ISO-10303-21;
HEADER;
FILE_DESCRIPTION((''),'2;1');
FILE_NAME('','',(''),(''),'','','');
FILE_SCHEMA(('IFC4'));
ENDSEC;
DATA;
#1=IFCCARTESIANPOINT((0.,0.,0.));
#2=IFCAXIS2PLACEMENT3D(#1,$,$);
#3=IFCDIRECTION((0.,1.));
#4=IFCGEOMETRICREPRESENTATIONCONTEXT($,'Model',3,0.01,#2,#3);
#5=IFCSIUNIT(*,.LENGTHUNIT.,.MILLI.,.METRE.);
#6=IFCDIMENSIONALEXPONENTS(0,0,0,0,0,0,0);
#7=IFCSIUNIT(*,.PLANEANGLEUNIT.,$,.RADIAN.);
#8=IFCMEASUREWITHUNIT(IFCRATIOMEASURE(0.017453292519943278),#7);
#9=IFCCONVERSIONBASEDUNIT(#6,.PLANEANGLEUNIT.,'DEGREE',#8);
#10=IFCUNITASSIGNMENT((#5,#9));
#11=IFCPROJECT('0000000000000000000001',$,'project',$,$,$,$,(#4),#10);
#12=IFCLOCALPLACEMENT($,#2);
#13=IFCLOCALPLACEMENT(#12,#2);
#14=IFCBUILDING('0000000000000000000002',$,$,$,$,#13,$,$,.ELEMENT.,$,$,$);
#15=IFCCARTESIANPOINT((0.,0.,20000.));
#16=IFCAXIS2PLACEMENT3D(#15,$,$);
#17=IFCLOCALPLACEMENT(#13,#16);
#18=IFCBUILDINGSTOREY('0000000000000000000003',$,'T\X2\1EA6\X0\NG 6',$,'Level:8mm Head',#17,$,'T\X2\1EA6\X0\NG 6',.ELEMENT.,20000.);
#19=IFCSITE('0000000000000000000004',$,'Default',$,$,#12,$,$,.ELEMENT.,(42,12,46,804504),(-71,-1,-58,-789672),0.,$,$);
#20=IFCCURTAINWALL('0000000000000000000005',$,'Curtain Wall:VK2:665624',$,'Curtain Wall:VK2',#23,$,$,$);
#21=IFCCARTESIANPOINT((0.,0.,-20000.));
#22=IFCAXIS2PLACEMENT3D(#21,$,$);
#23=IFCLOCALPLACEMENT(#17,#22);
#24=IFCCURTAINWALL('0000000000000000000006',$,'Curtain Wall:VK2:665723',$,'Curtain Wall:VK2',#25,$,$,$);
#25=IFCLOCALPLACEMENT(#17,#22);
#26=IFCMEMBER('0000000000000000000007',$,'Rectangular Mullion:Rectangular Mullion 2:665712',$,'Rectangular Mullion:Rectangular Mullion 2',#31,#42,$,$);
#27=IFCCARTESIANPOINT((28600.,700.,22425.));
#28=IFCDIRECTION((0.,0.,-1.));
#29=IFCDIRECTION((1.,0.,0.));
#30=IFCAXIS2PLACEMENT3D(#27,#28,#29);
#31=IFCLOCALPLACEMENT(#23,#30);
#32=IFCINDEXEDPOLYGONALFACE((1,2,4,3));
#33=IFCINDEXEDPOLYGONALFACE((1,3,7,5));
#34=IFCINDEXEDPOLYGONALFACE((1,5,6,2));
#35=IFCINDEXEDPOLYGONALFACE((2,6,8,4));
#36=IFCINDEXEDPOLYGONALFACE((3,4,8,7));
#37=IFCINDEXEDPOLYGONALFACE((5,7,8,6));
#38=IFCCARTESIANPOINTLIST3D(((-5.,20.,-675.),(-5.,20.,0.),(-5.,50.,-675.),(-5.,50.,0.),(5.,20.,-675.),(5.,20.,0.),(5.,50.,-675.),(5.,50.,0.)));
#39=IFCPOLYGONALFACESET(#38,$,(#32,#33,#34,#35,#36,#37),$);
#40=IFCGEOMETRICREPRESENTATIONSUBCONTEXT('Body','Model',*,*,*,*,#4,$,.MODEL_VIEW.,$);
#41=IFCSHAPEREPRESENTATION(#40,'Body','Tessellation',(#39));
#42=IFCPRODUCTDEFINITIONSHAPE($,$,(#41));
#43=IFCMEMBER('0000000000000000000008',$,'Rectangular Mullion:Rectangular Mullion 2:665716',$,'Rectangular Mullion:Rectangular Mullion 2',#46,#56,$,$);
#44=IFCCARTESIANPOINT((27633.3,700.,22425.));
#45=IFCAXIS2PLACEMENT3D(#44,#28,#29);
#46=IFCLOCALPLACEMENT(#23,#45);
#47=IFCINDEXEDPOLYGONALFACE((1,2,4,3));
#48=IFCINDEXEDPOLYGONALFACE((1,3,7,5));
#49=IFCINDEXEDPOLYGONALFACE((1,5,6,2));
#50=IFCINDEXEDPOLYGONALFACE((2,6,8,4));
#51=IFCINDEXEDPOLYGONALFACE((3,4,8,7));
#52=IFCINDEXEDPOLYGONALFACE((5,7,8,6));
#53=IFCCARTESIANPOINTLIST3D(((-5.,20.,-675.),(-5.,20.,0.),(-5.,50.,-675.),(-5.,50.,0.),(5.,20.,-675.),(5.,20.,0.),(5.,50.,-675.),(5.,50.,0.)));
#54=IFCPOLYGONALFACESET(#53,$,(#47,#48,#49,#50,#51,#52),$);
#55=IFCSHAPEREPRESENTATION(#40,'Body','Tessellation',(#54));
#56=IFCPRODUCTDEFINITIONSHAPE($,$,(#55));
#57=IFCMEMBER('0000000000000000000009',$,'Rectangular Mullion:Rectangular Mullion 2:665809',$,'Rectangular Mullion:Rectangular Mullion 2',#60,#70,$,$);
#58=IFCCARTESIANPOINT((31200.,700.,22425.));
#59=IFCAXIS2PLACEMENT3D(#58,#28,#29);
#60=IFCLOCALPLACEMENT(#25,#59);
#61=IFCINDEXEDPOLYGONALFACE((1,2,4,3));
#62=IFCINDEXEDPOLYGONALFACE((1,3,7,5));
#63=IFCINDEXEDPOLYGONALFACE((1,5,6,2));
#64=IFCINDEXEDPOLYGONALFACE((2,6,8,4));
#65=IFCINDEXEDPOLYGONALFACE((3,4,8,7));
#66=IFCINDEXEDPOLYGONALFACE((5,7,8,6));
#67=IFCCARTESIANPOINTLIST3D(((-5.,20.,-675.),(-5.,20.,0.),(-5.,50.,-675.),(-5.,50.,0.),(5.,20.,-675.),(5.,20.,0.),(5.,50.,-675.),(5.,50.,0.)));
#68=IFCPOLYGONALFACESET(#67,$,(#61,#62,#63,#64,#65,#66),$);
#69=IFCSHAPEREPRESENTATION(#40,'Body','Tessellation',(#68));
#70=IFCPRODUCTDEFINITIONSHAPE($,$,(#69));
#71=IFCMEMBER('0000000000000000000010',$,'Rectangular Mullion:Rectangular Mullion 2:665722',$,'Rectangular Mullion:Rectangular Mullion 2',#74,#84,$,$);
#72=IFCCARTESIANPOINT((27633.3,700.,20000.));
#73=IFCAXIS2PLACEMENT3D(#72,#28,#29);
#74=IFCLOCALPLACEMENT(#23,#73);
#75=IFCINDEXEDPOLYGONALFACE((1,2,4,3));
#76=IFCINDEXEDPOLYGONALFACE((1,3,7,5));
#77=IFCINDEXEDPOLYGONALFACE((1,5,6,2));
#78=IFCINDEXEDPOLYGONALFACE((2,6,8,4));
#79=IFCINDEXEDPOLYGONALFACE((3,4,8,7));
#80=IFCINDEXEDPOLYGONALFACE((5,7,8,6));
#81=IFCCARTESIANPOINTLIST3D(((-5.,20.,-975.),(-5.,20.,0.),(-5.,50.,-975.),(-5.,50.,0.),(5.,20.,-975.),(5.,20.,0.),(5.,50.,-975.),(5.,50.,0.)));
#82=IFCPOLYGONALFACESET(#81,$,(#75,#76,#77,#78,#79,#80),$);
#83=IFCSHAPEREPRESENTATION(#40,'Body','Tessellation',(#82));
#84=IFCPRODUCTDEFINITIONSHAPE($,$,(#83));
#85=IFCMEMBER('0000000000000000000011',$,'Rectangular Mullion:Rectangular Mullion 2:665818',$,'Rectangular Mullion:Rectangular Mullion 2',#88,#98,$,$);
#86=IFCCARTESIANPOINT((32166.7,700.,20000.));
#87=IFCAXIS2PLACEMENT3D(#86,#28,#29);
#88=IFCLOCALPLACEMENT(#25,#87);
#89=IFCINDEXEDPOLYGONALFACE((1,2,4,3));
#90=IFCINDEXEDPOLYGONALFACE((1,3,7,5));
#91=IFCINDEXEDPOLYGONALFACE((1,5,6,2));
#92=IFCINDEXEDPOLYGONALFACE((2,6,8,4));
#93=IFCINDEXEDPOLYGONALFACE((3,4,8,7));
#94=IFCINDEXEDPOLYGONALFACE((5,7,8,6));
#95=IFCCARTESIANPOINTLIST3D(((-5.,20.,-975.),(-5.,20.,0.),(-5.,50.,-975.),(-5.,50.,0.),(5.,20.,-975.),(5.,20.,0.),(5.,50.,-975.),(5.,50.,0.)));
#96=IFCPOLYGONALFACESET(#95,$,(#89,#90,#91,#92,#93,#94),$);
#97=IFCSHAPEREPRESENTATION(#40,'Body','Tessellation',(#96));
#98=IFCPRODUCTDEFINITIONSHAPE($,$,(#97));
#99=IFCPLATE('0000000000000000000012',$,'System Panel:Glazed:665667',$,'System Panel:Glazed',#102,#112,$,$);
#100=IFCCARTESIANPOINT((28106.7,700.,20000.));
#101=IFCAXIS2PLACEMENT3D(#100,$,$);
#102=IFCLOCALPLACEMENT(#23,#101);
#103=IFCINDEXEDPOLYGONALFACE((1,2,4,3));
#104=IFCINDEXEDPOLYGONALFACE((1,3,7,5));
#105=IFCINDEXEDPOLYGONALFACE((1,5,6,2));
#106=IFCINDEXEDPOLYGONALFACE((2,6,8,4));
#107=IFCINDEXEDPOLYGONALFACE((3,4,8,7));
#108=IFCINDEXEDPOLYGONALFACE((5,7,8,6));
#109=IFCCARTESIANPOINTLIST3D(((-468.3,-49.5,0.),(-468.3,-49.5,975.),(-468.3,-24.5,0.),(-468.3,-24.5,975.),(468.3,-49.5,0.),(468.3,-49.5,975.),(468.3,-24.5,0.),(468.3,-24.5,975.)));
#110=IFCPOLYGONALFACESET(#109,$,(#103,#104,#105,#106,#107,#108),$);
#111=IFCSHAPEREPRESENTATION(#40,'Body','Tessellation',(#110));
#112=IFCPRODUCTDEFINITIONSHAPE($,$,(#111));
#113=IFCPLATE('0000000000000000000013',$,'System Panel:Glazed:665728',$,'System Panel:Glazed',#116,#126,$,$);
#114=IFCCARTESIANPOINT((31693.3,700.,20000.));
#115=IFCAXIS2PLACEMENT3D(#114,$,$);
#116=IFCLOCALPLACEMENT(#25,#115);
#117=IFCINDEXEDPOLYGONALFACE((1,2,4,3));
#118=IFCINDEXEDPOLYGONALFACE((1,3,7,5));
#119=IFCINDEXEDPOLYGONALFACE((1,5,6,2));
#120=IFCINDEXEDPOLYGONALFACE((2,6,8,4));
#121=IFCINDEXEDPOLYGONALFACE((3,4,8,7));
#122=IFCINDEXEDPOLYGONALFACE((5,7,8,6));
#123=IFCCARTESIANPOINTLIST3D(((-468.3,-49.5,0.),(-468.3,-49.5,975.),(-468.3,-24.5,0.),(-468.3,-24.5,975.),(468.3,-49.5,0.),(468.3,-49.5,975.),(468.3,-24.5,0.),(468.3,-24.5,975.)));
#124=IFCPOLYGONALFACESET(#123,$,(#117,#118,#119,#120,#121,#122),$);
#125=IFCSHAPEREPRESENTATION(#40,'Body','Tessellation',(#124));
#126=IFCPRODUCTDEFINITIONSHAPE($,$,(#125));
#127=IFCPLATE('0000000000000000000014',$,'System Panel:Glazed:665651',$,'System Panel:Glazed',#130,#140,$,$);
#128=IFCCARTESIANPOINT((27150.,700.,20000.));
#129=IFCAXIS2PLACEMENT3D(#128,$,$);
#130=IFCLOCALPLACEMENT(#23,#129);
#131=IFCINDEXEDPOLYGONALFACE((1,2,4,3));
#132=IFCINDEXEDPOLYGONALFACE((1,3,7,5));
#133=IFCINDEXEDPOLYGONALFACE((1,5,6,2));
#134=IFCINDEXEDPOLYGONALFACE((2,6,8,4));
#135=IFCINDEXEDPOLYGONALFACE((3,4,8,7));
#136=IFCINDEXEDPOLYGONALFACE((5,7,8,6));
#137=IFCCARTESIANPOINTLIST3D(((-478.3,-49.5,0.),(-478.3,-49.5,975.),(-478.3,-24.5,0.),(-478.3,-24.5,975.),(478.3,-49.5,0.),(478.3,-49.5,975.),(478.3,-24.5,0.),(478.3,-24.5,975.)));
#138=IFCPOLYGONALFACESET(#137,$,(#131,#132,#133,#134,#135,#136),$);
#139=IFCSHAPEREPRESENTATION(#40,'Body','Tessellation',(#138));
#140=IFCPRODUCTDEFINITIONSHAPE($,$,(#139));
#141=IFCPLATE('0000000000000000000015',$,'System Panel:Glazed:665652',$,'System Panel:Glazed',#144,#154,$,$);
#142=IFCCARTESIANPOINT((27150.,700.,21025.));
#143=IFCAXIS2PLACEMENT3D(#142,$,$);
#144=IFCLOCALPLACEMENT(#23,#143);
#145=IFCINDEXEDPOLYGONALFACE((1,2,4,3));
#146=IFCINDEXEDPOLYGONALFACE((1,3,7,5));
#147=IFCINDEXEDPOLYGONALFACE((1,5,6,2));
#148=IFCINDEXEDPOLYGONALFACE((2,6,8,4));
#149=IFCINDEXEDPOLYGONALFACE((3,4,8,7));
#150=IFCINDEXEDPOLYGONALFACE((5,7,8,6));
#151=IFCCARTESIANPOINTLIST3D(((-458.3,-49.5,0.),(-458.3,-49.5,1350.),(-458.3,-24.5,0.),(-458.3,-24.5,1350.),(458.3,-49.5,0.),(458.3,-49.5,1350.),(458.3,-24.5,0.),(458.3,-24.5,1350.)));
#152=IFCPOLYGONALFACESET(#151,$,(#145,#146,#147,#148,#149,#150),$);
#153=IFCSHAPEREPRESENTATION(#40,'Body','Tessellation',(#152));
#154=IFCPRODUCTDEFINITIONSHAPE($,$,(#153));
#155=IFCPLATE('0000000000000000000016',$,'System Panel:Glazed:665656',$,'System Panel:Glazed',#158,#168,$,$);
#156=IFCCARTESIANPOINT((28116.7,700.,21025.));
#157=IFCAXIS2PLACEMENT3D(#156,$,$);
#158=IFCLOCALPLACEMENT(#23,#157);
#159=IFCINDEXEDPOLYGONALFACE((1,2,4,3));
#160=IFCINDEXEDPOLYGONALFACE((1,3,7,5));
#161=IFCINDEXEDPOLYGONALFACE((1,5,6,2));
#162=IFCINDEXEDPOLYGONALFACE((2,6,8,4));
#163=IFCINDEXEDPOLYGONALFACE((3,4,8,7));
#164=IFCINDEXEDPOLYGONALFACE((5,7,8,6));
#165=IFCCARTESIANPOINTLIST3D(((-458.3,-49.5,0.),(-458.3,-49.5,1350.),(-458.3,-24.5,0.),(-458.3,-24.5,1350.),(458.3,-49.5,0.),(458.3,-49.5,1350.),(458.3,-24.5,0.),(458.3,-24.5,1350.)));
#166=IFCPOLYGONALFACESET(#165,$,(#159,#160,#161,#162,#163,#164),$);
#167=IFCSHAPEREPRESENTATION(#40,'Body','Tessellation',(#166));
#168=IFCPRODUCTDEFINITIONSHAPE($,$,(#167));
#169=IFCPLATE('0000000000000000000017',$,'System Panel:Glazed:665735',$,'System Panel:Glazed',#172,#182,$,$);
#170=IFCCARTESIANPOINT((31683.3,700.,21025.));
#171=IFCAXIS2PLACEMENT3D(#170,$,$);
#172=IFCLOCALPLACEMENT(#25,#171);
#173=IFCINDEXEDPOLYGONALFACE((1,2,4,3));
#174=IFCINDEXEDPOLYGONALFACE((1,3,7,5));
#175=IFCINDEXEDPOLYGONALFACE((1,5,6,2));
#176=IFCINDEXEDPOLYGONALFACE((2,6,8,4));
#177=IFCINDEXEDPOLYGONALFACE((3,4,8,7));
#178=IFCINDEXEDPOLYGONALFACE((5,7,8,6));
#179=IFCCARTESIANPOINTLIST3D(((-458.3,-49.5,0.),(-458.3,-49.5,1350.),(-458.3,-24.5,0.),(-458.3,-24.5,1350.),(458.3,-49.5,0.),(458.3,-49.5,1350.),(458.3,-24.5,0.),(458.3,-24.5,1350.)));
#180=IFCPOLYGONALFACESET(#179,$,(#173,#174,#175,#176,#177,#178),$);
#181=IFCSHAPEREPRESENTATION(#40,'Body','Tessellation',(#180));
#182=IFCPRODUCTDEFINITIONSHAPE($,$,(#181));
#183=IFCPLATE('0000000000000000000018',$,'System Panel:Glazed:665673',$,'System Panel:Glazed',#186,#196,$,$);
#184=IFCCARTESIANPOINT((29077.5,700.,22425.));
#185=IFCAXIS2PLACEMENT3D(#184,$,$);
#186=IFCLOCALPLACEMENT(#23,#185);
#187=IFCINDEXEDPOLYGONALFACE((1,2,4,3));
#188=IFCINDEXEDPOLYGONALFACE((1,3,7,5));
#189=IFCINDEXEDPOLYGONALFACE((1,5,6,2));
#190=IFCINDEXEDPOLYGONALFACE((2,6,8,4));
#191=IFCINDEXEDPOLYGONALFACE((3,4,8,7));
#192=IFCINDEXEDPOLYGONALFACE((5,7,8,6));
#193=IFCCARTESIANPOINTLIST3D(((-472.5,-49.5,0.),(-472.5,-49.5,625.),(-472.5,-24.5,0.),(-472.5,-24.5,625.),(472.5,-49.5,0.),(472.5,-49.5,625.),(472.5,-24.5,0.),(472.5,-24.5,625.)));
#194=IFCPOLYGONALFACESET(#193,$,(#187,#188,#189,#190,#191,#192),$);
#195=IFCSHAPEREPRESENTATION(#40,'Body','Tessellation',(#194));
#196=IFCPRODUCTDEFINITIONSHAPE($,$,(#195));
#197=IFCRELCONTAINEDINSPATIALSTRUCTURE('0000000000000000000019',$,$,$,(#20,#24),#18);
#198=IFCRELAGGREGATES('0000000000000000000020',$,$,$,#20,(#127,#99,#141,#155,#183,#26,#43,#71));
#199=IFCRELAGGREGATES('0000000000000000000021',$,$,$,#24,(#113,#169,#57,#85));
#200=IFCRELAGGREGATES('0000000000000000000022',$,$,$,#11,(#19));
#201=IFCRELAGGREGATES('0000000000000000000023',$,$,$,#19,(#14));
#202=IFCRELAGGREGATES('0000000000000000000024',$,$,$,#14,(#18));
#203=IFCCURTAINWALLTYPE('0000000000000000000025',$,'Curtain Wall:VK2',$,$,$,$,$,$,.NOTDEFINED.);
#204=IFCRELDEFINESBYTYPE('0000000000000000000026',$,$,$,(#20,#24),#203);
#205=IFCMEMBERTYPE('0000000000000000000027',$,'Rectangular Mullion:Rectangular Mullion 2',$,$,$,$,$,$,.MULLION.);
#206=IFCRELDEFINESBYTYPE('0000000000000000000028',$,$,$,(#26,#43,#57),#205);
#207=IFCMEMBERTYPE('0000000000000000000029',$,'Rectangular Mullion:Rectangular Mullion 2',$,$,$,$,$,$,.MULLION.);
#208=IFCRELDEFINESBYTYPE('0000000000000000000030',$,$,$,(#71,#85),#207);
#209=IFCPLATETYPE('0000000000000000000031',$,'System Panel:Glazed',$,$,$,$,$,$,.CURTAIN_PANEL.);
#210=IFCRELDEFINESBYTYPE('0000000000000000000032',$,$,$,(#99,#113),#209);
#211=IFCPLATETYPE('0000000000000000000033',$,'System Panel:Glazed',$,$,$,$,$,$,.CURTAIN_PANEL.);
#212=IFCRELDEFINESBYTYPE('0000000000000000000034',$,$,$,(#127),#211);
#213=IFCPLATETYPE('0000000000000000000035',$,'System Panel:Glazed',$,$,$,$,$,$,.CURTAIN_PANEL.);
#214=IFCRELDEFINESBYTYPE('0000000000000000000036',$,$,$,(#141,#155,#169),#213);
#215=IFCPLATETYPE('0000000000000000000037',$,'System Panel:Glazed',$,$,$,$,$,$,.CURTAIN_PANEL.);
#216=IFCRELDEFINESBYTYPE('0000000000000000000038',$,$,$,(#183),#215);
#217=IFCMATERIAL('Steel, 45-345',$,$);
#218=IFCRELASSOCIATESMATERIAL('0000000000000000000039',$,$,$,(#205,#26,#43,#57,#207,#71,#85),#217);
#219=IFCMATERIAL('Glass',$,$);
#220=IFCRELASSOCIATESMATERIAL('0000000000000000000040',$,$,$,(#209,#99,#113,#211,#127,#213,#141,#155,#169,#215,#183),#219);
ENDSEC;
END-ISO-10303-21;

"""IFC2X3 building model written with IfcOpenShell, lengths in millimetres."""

from ifc_helpers import new_model, entity, si_unit, converted_unit, direction, frame, frame_2d, origin, origin_2d_with_axis, place, context, subcontext, project, spatial, rectangle, extrude, source, transform, mapped, material, type_object, type_shapes, element, aggregate, save


model = new_model("IFC2X3")

# Units and contexts
model_context = context("Model", 3, precision=0.01, world=origin(), true_north=direction((0.0, 1.0)))
body_context = subcontext(model_context, "Body", "Model", "MODEL_VIEW")
ifc_project = project(units=[si_unit("LENGTHUNIT", "METRE", prefix="MILLI"), converted_unit("PLANEANGLEUNIT", "DEGREE", entity("IfcRatioMeasure", 0.017453292519943278), si_unit("PLANEANGLEUNIT", "RADIAN"), dimensions=[0, 0, 0, 0, 0, 0, 0])], contexts=[model_context])

# Site, building, storey
site_placement = place(None, origin())
site = spatial("IfcSite", under=ifc_project, at=site_placement, Name="Default", CompositionType="ELEMENT", RefLatitude=(42, 12, 46, 804504), RefLongitude=(-71, -1, -58, -789672), RefElevation=0.0)
building_placement = place(site_placement, origin())
building = spatial("IfcBuilding", under=site, at=building_placement, CompositionType="ELEMENT")
storey_placement = place(building_placement, frame((0.0, 0.0, 20000.0)))
storey = spatial("IfcBuildingStorey", under=building, at=storey_placement, Name="TẦNG 6", ObjectType="Level:8mm Head", LongName="TẦNG 6", CompositionType="ELEMENT", Elevation=20000.0)

# Curtain wall
curtain_wall_type = type_object("IfcCurtainWallType", Name="Curtain Wall:VK2", PredefinedType="NOTDEFINED")
curtain_wall_1_placement = place(storey_placement, frame((0.0, 0.0, -20000.0)))
curtain_wall_1 = element("IfcCurtainWall", 1, at=curtain_wall_1_placement, inside=storey, type_object=curtain_wall_type, Name="Curtain Wall:VK2:665624", ObjectType="Curtain Wall:VK2")
ifc_material_1 = material(Name="Steel, 45-345")

# Curtain wall
curtain_wall_2_placement = place(storey_placement, frame((0.0, 0.0, -20000.0)))
curtain_wall_2 = element("IfcCurtainWall", 2, at=curtain_wall_2_placement, inside=storey, type_object=curtain_wall_type, Name="Curtain Wall:VK2:665723", ObjectType="Curtain Wall:VK2")

# Members
member_type_1 = type_object("IfcMemberType", Name="Rectangular Mullion:Rectangular Mullion 2", PredefinedType="MULLION", material=ifc_material_1)
shared_shape_1 = source(origin(), body_context, "Body", "SweptSolid", [
    extrude(rectangle(XDim=30.0, YDim=10.0, at=origin_2d_with_axis()), frame((0.0, 35.0, -675.0), z_axis=(0.0, 0.0, 1.0), x_axis=(0.0, -1.0, 0.0)), (0.0, 0.0, 1.0), 675.0),
])
type_shapes(member_type_1, [shared_shape_1])
member_1_placement = place(curtain_wall_1_placement, frame((28600.0, 700.0, 22425.0), z_axis=(0.0, 0.0, -1.0), x_axis=(1.0, 0.0, 0.0)))
member_1 = element("IfcMember", 3, at=member_1_placement, type_object=member_type_1, material=ifc_material_1, Name="Rectangular Mullion:Rectangular Mullion 2:665712", ObjectType="Rectangular Mullion:Rectangular Mullion 2", context=body_context, shape_type="MappedRepresentation", body=[
    mapped(shared_shape_1, transform((0.0, 0.0, 0.0), scale=1.0)),
])
member_2_placement = place(curtain_wall_1_placement, frame((27633.3, 700.0, 22425.0), z_axis=(0.0, 0.0, -1.0), x_axis=(1.0, 0.0, 0.0)))
member_2 = element("IfcMember", 4, at=member_2_placement, type_object=member_type_1, material=ifc_material_1, Name="Rectangular Mullion:Rectangular Mullion 2:665716", ObjectType="Rectangular Mullion:Rectangular Mullion 2", context=body_context, shape_type="MappedRepresentation", body=[
    mapped(shared_shape_1, transform((0.0, 0.0, 0.0), scale=1.0)),
])
member_3_placement = place(curtain_wall_2_placement, frame((31200.0, 700.0, 22425.0), z_axis=(0.0, 0.0, -1.0), x_axis=(1.0, 0.0, 0.0)))
member_3 = element("IfcMember", 5, at=member_3_placement, type_object=member_type_1, material=ifc_material_1, Name="Rectangular Mullion:Rectangular Mullion 2:665809", ObjectType="Rectangular Mullion:Rectangular Mullion 2", context=body_context, shape_type="MappedRepresentation", body=[
    mapped(shared_shape_1, transform((0.0, 0.0, 0.0), scale=1.0)),
])
member_type_2 = type_object("IfcMemberType", Name="Rectangular Mullion:Rectangular Mullion 2", PredefinedType="MULLION", material=ifc_material_1)
shared_shape_2 = source(origin(), body_context, "Body", "SweptSolid", [
    extrude(rectangle(XDim=30.0, YDim=10.0, at=origin_2d_with_axis()), frame((0.0, 35.0, -975.0), z_axis=(0.0, 0.0, 1.0), x_axis=(0.0, -1.0, 0.0)), (0.0, 0.0, 1.0), 975.0),
])
type_shapes(member_type_2, [shared_shape_2])
member_4_placement = place(curtain_wall_1_placement, frame((27633.3, 700.0, 20000.0), z_axis=(0.0, 0.0, -1.0), x_axis=(1.0, 0.0, 0.0)))
member_4 = element("IfcMember", 6, at=member_4_placement, type_object=member_type_2, material=ifc_material_1, Name="Rectangular Mullion:Rectangular Mullion 2:665722", ObjectType="Rectangular Mullion:Rectangular Mullion 2", context=body_context, shape_type="MappedRepresentation", body=[
    mapped(shared_shape_2, transform((0.0, 0.0, 0.0), scale=1.0)),
])
member_5_placement = place(curtain_wall_2_placement, frame((32166.7, 700.0, 20000.0), z_axis=(0.0, 0.0, -1.0), x_axis=(1.0, 0.0, 0.0)))
member_5 = element("IfcMember", 7, at=member_5_placement, type_object=member_type_2, material=ifc_material_1, Name="Rectangular Mullion:Rectangular Mullion 2:665818", ObjectType="Rectangular Mullion:Rectangular Mullion 2", context=body_context, shape_type="MappedRepresentation", body=[
    mapped(shared_shape_2, transform((0.0, 0.0, 0.0), scale=1.0)),
])

# Plates
ifc_material_2 = material(Name="Glass")
plate_type_1 = type_object("IfcPlateType", Name="System Panel:Glazed", PredefinedType="CURTAIN_PANEL", material=ifc_material_2)
shared_shape_3 = source(origin(), body_context, "Body", "SweptSolid", [
    extrude(rectangle(XDim=25.0, YDim=936.7, at=frame_2d((0.0, 0.0), x_axis=(1.0, 0.0))), frame((0.0, -37.0, 0.0), z_axis=(0.0, 0.0, 1.0), x_axis=(0.0, 1.0, 0.0)), (0.0, 0.0, 1.0), 975.0),
])
type_shapes(plate_type_1, [shared_shape_3])
plate_1_placement = place(curtain_wall_1_placement, frame((28106.7, 700.0, 20000.0)))
plate_1 = element("IfcPlate", 8, at=plate_1_placement, type_object=plate_type_1, material=ifc_material_2, Name="System Panel:Glazed:665667", ObjectType="System Panel:Glazed", context=body_context, shape_type="MappedRepresentation", body=[
    mapped(shared_shape_3, transform((0.0, 0.0, 0.0), scale=1.0)),
])
plate_2_placement = place(curtain_wall_2_placement, frame((31693.3, 700.0, 20000.0)))
plate_2 = element("IfcPlate", 9, at=plate_2_placement, type_object=plate_type_1, material=ifc_material_2, Name="System Panel:Glazed:665728", ObjectType="System Panel:Glazed", context=body_context, shape_type="MappedRepresentation", body=[
    mapped(shared_shape_3, transform((0.0, 0.0, 0.0), scale=1.0)),
])
plate_type_2 = type_object("IfcPlateType", Name="System Panel:Glazed", PredefinedType="CURTAIN_PANEL", material=ifc_material_2)
shared_shape_4 = source(origin(), body_context, "Body", "SweptSolid", [
    extrude(rectangle(XDim=25.0, YDim=956.7, at=frame_2d((0.0, 0.0), x_axis=(1.0, 0.0))), frame((0.0, -37.0, 0.0), z_axis=(0.0, 0.0, 1.0), x_axis=(0.0, 1.0, 0.0)), (0.0, 0.0, 1.0), 975.0),
])
type_shapes(plate_type_2, [shared_shape_4])
plate_3_placement = place(curtain_wall_1_placement, frame((27150.0, 700.0, 20000.0)))
plate_3 = element("IfcPlate", 10, at=plate_3_placement, type_object=plate_type_2, material=ifc_material_2, Name="System Panel:Glazed:665651", ObjectType="System Panel:Glazed", context=body_context, shape_type="MappedRepresentation", body=[
    mapped(shared_shape_4, transform((0.0, 0.0, 0.0), scale=1.0)),
])
plate_type_3 = type_object("IfcPlateType", Name="System Panel:Glazed", PredefinedType="CURTAIN_PANEL", material=ifc_material_2)
shared_shape_5 = source(origin(), body_context, "Body", "SweptSolid", [
    extrude(rectangle(XDim=25.0, YDim=916.7, at=frame_2d((0.0, 0.0), x_axis=(1.0, 0.0))), frame((0.0, -37.0, 0.0), z_axis=(0.0, 0.0, 1.0), x_axis=(0.0, 1.0, 0.0)), (0.0, 0.0, 1.0), 1350.0),
])
type_shapes(plate_type_3, [shared_shape_5])
plate_4_placement = place(curtain_wall_1_placement, frame((27150.0, 700.0, 21025.0)))
plate_4 = element("IfcPlate", 11, at=plate_4_placement, type_object=plate_type_3, material=ifc_material_2, Name="System Panel:Glazed:665652", ObjectType="System Panel:Glazed", context=body_context, shape_type="MappedRepresentation", body=[
    mapped(shared_shape_5, transform((0.0, 0.0, 0.0), scale=1.0)),
])
plate_5_placement = place(curtain_wall_1_placement, frame((28116.7, 700.0, 21025.0)))
plate_5 = element("IfcPlate", 12, at=plate_5_placement, type_object=plate_type_3, material=ifc_material_2, Name="System Panel:Glazed:665656", ObjectType="System Panel:Glazed", context=body_context, shape_type="MappedRepresentation", body=[
    mapped(shared_shape_5, transform((0.0, 0.0, 0.0), scale=1.0)),
])
plate_6_placement = place(curtain_wall_2_placement, frame((31683.3, 700.0, 21025.0)))
plate_6 = element("IfcPlate", 13, at=plate_6_placement, type_object=plate_type_3, material=ifc_material_2, Name="System Panel:Glazed:665735", ObjectType="System Panel:Glazed", context=body_context, shape_type="MappedRepresentation", body=[
    mapped(shared_shape_5, transform((0.0, 0.0, 0.0), scale=1.0)),
])
plate_type_4 = type_object("IfcPlateType", Name="System Panel:Glazed", PredefinedType="CURTAIN_PANEL", material=ifc_material_2)
shared_shape_6 = source(origin(), body_context, "Body", "SweptSolid", [
    extrude(rectangle(XDim=25.0, YDim=945.0, at=frame_2d((0.0, 0.0), x_axis=(1.0, 0.0))), frame((0.0, -37.0, 0.0), z_axis=(0.0, 0.0, 1.0), x_axis=(0.0, 1.0, 0.0)), (0.0, 0.0, 1.0), 625.0),
])
type_shapes(plate_type_4, [shared_shape_6])
plate_7_placement = place(curtain_wall_1_placement, frame((29077.5, 700.0, 22425.0)))
plate_7 = element("IfcPlate", 14, at=plate_7_placement, type_object=plate_type_4, material=ifc_material_2, Name="System Panel:Glazed:665673", ObjectType="System Panel:Glazed", context=body_context, shape_type="MappedRepresentation", body=[
    mapped(shared_shape_6, transform((0.0, 0.0, 0.0), scale=1.0)),
])
aggregate(curtain_wall_1, [plate_3, plate_1, plate_4, plate_5, plate_7, member_1, member_2, member_4])
aggregate(curtain_wall_2, [plate_2, plate_6, member_3, member_5])

save(model, "model.ifc")
